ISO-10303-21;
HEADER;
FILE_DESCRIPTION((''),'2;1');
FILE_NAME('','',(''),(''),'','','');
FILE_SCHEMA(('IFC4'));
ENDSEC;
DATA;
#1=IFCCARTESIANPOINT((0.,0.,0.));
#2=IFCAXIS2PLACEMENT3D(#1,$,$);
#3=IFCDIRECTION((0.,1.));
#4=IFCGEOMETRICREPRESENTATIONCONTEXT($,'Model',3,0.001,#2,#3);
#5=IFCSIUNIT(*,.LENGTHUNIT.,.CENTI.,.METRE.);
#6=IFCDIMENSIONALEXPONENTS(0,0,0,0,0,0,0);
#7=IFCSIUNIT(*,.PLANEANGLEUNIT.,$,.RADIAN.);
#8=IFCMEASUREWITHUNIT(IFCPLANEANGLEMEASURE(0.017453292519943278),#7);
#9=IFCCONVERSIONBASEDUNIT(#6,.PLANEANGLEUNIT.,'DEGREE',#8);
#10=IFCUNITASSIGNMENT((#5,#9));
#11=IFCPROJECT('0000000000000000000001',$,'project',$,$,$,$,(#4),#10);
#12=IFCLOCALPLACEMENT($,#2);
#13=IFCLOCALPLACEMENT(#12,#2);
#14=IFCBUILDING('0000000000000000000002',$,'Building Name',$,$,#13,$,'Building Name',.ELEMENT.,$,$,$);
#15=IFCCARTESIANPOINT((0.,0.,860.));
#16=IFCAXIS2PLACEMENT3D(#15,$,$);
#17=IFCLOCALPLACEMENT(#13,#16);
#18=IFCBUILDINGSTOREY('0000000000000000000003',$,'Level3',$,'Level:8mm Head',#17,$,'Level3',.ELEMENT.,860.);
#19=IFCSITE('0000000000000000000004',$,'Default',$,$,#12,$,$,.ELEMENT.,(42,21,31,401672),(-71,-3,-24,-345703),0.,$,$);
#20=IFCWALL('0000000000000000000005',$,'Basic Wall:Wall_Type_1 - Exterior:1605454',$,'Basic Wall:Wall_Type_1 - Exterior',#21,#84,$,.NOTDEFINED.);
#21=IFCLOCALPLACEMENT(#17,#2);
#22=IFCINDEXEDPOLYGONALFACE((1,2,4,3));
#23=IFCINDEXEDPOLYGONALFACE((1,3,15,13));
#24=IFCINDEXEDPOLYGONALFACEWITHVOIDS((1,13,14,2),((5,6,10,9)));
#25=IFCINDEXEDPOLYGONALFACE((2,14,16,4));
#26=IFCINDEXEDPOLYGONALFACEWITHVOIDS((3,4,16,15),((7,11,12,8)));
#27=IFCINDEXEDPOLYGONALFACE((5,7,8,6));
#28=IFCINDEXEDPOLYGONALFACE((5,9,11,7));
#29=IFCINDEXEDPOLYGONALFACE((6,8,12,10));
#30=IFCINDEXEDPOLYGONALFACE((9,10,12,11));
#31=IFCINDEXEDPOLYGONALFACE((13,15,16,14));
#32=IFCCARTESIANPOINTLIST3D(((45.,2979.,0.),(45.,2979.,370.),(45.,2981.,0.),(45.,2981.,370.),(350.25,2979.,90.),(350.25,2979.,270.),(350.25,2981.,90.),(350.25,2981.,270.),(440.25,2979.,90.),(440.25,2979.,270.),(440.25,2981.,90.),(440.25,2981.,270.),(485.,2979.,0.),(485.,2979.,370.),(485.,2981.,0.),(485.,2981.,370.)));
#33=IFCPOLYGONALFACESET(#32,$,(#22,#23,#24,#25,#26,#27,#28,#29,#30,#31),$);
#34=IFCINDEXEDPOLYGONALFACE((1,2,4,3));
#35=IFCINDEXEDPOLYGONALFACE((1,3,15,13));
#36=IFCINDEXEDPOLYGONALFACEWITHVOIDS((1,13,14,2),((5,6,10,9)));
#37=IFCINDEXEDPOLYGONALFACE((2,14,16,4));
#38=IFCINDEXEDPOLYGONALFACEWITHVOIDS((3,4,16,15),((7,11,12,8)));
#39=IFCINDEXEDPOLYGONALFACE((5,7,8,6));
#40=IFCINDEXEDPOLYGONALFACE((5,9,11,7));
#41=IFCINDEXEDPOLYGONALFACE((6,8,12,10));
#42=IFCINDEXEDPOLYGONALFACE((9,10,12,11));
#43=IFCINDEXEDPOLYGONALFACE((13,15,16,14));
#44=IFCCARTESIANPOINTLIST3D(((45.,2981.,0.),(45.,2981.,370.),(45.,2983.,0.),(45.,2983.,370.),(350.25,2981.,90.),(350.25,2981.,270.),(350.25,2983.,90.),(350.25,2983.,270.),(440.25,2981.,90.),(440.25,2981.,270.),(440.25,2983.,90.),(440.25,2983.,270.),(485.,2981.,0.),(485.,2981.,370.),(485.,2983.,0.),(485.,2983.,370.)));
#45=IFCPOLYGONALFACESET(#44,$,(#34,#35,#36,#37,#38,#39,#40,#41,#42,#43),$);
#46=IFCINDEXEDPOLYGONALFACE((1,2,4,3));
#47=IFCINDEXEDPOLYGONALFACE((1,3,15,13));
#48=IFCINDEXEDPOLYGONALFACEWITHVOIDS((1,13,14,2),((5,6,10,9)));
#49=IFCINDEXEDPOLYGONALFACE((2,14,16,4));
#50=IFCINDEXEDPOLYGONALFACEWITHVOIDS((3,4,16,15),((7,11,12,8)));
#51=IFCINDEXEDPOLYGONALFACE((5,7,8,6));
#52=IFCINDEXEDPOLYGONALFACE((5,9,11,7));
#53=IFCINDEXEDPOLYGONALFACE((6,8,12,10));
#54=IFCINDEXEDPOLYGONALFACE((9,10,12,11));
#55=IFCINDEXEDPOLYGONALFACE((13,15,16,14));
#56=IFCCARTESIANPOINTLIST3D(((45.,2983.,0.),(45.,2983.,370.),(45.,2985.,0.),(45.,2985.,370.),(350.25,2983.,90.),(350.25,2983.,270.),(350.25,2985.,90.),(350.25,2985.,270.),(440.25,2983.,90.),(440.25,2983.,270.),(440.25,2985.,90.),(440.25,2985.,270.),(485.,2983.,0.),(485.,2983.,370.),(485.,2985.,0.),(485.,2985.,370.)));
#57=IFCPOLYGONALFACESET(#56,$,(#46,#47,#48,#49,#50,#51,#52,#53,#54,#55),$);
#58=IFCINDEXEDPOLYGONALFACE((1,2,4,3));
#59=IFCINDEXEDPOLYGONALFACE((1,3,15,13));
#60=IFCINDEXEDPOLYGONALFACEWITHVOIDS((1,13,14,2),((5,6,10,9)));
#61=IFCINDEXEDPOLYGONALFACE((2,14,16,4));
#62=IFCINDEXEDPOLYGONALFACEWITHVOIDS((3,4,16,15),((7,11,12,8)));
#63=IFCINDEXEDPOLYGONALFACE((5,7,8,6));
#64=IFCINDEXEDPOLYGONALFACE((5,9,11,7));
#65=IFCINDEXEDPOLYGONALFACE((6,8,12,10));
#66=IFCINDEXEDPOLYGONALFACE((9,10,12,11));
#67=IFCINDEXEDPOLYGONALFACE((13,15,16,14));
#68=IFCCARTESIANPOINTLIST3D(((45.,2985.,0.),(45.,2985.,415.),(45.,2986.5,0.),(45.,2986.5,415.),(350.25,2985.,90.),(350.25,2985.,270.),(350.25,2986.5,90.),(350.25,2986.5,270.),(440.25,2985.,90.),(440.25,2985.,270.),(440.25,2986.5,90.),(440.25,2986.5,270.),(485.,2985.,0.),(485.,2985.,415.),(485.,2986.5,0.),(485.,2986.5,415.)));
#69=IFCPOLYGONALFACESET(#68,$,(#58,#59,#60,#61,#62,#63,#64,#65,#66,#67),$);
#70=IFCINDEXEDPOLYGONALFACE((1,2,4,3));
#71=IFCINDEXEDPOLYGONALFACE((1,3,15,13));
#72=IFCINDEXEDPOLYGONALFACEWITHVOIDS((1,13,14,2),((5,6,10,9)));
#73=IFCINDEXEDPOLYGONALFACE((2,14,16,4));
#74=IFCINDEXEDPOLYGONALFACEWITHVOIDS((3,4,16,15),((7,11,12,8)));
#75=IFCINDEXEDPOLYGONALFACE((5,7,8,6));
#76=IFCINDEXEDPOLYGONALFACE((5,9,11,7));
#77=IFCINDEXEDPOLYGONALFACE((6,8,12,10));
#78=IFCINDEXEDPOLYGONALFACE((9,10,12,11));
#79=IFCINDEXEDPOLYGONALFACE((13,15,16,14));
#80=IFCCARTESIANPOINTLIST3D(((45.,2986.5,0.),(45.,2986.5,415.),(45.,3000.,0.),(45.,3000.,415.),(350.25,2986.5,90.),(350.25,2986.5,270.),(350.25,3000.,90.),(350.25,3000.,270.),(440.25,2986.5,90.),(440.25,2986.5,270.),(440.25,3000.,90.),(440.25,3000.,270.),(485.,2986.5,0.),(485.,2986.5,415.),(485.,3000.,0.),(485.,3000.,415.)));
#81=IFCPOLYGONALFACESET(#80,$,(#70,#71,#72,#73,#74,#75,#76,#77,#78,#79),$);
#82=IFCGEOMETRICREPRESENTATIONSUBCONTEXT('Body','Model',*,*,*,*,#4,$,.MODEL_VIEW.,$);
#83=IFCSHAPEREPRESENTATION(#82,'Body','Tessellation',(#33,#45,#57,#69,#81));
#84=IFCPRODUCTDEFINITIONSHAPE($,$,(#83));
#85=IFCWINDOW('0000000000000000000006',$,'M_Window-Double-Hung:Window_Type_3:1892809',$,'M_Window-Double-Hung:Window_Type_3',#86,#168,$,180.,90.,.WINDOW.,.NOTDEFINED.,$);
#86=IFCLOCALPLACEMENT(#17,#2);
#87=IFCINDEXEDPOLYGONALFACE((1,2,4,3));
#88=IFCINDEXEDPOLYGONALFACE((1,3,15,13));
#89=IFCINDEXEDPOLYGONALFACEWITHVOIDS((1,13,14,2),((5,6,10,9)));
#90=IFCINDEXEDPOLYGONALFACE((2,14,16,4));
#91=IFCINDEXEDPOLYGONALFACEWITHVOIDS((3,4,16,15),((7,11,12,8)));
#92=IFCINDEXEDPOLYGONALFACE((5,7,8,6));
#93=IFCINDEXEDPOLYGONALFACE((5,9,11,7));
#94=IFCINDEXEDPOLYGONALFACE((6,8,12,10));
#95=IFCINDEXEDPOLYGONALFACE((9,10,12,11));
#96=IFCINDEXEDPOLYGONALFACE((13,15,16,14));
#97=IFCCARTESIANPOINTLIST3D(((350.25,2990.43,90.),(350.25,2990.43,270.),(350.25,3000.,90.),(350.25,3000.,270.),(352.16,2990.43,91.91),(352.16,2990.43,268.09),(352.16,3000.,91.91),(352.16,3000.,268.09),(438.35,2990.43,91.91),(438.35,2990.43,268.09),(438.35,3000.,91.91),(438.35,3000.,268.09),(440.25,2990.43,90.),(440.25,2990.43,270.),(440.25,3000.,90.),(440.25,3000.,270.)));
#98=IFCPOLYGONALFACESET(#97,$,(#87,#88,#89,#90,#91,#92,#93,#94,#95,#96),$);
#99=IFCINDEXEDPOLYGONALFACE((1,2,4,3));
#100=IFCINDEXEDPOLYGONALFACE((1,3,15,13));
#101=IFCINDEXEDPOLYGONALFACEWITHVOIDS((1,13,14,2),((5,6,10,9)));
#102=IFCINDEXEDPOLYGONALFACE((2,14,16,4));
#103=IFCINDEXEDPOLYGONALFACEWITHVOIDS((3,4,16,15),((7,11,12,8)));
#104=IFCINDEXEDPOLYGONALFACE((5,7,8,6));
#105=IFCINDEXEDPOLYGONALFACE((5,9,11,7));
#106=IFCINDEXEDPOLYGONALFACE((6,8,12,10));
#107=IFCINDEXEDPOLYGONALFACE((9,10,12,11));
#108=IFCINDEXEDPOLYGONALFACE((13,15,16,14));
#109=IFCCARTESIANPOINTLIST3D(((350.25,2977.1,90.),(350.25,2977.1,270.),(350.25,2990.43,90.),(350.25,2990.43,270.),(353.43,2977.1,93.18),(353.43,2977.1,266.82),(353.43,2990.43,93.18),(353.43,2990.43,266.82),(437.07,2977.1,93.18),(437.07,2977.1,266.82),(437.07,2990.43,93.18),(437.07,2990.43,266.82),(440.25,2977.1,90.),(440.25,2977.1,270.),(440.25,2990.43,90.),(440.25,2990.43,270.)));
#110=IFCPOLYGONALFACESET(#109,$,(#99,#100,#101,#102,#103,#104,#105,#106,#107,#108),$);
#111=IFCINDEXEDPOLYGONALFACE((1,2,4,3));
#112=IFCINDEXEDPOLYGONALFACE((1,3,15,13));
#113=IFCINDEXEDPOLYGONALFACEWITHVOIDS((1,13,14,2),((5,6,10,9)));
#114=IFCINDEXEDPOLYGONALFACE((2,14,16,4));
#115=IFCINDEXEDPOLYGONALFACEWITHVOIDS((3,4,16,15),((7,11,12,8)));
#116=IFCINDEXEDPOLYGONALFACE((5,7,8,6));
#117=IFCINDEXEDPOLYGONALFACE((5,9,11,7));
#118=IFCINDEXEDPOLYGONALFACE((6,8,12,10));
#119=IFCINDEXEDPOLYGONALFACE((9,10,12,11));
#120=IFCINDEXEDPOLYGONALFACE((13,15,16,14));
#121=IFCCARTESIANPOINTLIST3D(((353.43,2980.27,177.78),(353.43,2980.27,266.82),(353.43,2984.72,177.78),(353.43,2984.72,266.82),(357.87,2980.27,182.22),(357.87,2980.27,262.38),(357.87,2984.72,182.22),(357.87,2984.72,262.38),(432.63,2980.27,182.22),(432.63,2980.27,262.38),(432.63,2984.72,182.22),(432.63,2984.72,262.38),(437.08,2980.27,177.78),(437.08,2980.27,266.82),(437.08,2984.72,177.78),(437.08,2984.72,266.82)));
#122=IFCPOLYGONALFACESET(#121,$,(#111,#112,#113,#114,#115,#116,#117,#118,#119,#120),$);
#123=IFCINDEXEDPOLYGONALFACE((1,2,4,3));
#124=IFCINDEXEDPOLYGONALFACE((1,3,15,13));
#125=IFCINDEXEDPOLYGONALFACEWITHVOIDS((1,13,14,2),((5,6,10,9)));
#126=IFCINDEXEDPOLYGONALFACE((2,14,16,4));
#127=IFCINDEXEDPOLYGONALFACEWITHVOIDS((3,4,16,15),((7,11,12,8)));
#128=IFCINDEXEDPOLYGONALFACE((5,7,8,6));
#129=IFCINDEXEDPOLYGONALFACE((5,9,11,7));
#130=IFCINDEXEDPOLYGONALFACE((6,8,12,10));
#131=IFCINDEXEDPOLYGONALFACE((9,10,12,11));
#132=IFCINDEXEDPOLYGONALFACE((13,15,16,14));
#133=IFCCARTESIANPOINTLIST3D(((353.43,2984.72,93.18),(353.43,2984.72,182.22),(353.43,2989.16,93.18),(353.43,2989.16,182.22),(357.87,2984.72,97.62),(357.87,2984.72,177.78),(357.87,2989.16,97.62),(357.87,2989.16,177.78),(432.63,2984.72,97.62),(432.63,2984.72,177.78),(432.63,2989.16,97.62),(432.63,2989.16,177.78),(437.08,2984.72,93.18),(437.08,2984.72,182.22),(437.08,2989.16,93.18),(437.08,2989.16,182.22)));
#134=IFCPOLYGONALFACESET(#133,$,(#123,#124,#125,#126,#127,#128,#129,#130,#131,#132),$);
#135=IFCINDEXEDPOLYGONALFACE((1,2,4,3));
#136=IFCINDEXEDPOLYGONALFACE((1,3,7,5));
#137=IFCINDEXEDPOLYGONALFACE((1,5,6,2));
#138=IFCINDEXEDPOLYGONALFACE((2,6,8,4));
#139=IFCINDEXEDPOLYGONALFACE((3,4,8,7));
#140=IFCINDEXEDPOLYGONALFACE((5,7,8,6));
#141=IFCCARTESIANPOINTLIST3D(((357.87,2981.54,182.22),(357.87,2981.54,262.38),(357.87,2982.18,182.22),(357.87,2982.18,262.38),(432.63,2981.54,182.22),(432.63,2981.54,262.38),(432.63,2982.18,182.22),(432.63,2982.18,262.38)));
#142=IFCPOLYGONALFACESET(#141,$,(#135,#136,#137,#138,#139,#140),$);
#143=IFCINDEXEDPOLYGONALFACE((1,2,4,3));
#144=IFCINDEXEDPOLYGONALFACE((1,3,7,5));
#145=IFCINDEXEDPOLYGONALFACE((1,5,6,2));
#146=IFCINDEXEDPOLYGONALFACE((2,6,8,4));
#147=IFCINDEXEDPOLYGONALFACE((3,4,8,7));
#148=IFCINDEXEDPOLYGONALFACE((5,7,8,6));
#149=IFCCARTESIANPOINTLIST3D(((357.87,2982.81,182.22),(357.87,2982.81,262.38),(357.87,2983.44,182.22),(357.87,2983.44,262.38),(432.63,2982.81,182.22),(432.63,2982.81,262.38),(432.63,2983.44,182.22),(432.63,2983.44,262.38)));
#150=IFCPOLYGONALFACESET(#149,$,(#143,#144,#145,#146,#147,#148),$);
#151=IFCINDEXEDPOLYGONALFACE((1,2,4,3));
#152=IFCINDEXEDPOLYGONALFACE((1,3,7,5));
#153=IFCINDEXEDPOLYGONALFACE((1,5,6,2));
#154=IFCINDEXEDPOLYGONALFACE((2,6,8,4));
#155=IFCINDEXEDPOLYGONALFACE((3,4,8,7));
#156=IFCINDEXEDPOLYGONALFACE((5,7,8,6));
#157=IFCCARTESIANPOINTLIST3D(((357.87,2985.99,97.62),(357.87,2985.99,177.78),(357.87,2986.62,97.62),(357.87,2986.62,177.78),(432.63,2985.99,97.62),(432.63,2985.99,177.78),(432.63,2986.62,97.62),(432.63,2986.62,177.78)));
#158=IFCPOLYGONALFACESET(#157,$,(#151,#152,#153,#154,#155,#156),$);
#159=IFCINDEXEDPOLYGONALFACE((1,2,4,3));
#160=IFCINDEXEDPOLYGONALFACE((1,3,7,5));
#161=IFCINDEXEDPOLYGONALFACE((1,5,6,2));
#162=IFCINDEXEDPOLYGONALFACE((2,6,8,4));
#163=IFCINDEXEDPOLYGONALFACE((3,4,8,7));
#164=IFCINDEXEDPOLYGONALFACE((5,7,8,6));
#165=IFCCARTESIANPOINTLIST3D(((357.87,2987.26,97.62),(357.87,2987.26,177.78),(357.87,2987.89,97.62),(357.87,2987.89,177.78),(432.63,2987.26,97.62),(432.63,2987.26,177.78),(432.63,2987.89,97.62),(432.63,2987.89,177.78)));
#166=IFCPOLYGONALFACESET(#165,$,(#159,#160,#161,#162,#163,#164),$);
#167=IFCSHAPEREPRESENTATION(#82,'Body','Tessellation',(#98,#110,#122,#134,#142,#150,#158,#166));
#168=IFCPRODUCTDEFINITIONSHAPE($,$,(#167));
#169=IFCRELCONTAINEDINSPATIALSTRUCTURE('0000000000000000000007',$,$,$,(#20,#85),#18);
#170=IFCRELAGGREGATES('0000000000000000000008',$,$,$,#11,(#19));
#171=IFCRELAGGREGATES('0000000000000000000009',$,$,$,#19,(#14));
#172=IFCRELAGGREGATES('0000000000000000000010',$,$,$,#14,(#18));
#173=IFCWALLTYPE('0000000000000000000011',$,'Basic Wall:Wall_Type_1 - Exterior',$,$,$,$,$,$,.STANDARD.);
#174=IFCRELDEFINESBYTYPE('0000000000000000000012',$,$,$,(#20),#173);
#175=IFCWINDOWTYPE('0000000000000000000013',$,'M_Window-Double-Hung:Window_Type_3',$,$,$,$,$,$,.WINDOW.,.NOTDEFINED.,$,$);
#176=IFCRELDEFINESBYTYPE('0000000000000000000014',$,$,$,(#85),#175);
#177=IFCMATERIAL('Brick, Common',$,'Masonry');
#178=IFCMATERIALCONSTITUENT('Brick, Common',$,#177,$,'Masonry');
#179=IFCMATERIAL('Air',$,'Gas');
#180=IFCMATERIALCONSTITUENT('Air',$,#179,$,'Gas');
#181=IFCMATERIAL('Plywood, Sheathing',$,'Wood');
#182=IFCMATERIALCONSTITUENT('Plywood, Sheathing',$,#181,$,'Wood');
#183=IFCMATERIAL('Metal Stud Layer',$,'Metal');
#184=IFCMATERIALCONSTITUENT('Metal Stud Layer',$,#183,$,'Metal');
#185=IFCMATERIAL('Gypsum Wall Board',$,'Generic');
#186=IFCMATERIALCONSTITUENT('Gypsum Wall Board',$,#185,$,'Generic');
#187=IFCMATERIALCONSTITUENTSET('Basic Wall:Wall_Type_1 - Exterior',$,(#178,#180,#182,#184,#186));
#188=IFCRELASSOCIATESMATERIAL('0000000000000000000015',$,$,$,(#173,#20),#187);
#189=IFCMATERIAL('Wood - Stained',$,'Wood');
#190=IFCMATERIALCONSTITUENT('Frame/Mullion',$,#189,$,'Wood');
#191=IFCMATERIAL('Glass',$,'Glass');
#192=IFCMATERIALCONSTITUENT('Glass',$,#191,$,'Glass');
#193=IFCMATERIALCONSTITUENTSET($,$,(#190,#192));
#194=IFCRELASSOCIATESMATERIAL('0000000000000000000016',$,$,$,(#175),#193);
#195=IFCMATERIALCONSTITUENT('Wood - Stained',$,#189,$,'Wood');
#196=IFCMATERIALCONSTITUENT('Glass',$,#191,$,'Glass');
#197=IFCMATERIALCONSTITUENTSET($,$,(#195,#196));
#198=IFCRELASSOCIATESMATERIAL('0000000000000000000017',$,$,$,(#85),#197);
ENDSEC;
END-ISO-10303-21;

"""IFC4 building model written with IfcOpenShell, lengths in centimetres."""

from ifc_helpers import new_model, entity, si_unit, converted_unit, direction, frame, origin, place, context, subcontext, project, spatial, indexed_curve, outline, extrude, source, transform, mapped, material, constituent, constituent_set, type_object, type_shapes, element, fill, save


model = new_model("IFC4")

# Units and contexts
model_context = context("Model", 3, precision=0.001, world=origin(), true_north=direction((0.0, 1.0)))
body_context = subcontext(model_context, "Body", "Model", "MODEL_VIEW")
ifc_project = project(units=[si_unit("LENGTHUNIT", "METRE", prefix="CENTI"), converted_unit("PLANEANGLEUNIT", "DEGREE", entity("IfcPlaneAngleMeasure", 0.017453292519943278), si_unit("PLANEANGLEUNIT", "RADIAN"), dimensions=[0, 0, 0, 0, 0, 0, 0])], contexts=[model_context])

# Site, building, storey
site_placement = place(None, origin())
site = spatial("IfcSite", under=ifc_project, at=site_placement, Name="Default", CompositionType="ELEMENT", RefLatitude=(42, 21, 31, 401672), RefLongitude=(-71, -3, -24, -345703), RefElevation=0.0)
building_placement = place(site_placement, origin())
building = spatial("IfcBuilding", under=site, at=building_placement, Name="Building Name", LongName="Building Name", CompositionType="ELEMENT")
storey_placement = place(building_placement, frame((0.0, 0.0, 860.0)))
storey = spatial("IfcBuildingStorey", under=building, at=storey_placement, Name="Level3", ObjectType="Level:8mm Head", LongName="Level3", CompositionType="ELEMENT", Elevation=860.0)

# Wall, opening, window
ifc_material_1 = material(Name="Brick, Common", Category="Masonry")
ifc_constituent_1 = constituent(ifc_material_1, Name="Brick, Common", Category="Masonry")
ifc_material_2 = material(Name="Air", Category="Gas")
ifc_constituent_2 = constituent(ifc_material_2, Name="Air", Category="Gas")
ifc_material_3 = material(Name="Plywood, Sheathing", Category="Wood")
ifc_constituent_3 = constituent(ifc_material_3, Name="Plywood, Sheathing", Category="Wood")
ifc_material_4 = material(Name="Metal Stud Layer", Category="Metal")
ifc_constituent_4 = constituent(ifc_material_4, Name="Metal Stud Layer", Category="Metal")
ifc_material_5 = material(Name="Gypsum Wall Board", Category="Generic")
ifc_constituent_5 = constituent(ifc_material_5, Name="Gypsum Wall Board", Category="Generic")
ifc_constituent_set_1 = constituent_set(constituents=[ifc_constituent_1, ifc_constituent_2, ifc_constituent_3, ifc_constituent_4, ifc_constituent_5], Name="Basic Wall:Wall_Type_1 - Exterior")
wall_type_1 = type_object("IfcWallType", Name="Basic Wall:Wall_Type_1 - Exterior", PredefinedType="STANDARD", material=ifc_constituent_set_1)
wall_1_placement = place(storey_placement, frame((45.0, 2989.5, 0.0)))
wall_1 = element("IfcWall", 1, at=wall_1_placement, inside=storey, type_object=wall_type_1, material=ifc_constituent_set_1, Name="Basic Wall:Wall_Type_1 - Exterior:1605454", ObjectType="Basic Wall:Wall_Type_1 - Exterior", PredefinedType="NOTDEFINED", context=body_context, shape_type="SweptSolid", body=[
    extrude(outline(indexed_curve([(-185.0, -240.63), (185.0, -240.63), (185.0, 16.37), (185.0, 24.87), (185.0, 199.38), (-185.0, 199.38), (-185.0, 24.87), (-185.0, 16.37), (-185.0, -240.63)], self_intersect=False), holes=[indexed_curve([(85.0, 154.62), (85.0, 64.62), (-95.0, 64.62), (-95.0, 154.62), (85.0, 154.62)], self_intersect=False)]), frame((240.63, -10.5, 185.0), z_axis=(0.0, 1.0, 0.0), x_axis=(0.0, 0.0, 1.0)), (0.0, 0.0, 1.0), 2.0),
    extrude(outline(indexed_curve([(-185.0, -220.0), (185.0, -220.0), (185.0, 220.0), (-185.0, 220.0), (-185.0, -220.0)], self_intersect=False), holes=[indexed_curve([(85.0, 175.25), (85.0, 85.25), (-95.0, 85.25), (-95.0, 175.25), (85.0, 175.25)], self_intersect=False)]), frame((220.0, -8.5, 185.0), z_axis=(0.0, 1.0, 0.0), x_axis=(0.0, 0.0, 1.0)), (0.0, 0.0, 1.0), 2.0),
    extrude(outline(indexed_curve([(-185.0, -220.0), (185.0, -220.0), (185.0, 220.0), (-185.0, 220.0), (-185.0, -220.0)], self_intersect=False), holes=[indexed_curve([(85.0, 175.25), (85.0, 85.25), (-95.0, 85.25), (-95.0, 175.25), (85.0, 175.25)], self_intersect=False)]), frame((220.0, -6.5, 185.0), z_axis=(0.0, 1.0, 0.0), x_axis=(0.0, 0.0, 1.0)), (0.0, 0.0, 1.0), 2.0),
    extrude(outline(indexed_curve([(-261.67, -220.0), (108.33, -220.0), (153.33, -220.0), (153.33, 220.0), (108.33, 220.0), (-261.67, 220.0), (-261.67, -220.0)], self_intersect=False), holes=[indexed_curve([(8.33, 175.25), (8.33, 85.25), (-171.67, 85.25), (-171.67, 175.25), (8.33, 175.25)], self_intersect=False)]), frame((220.0, -4.5, 261.67), z_axis=(0.0, 1.0, 0.0), x_axis=(0.0, 0.0, 1.0)), (0.0, 0.0, 1.0), 1.5),
    extrude(outline(indexed_curve([(-207.5, -220.0), (207.5, -220.0), (207.5, 220.0), (-207.5, 220.0), (-207.5, -220.0)], self_intersect=False), holes=[indexed_curve([(62.5, 175.25), (62.5, 85.25), (-117.5, 85.25), (-117.5, 175.25), (62.5, 175.25)], self_intersect=False)]), frame((220.0, -3.0, 207.5), z_axis=(0.0, 1.0, 0.0), x_axis=(0.0, 0.0, 1.0)), (0.0, 0.0, 1.0), 13.5),
])
opening_1_placement = place(wall_1_placement, frame((395.25, 10.5, 90.0)))
opening_1 = element("IfcOpeningElement", 2, at=opening_1_placement, cuts=wall_1, PredefinedType="OPENING", context=body_context, shape_type="SweptSolid", body=[
    extrude(outline(indexed_curve([(180.0, 0.0), (180.0, 90.0), (0.0, 90.0), (0.0, 0.0), (180.0, 0.0)], self_intersect=False)), frame((0.0, 0.0, 0.0), z_axis=(0.0, -1.0, 0.0), x_axis=(0.0, 0.0, 1.0)), (0.0, 0.0, 1.0), 21.0),
])
ifc_material_6 = material(Name="Wood - Stained", Category="Wood")
ifc_constituent_6 = constituent(ifc_material_6, Name="Wood - Stained", Category="Wood")
ifc_material_7 = material(Name="Glass", Category="Glass")
ifc_constituent_7 = constituent(ifc_material_7, Name="Glass", Category="Glass")
ifc_constituent_set_2 = constituent_set(constituents=[ifc_constituent_6, ifc_constituent_7])
ifc_constituent_8 = constituent(ifc_material_6, Name="Frame/Mullion", Category="Wood")
ifc_constituent_9 = constituent(ifc_material_7, Name="Glass", Category="Glass")
ifc_constituent_set_3 = constituent_set(constituents=[ifc_constituent_8, ifc_constituent_9])
window_type = type_object("IfcWindowType", Name="M_Window-Double-Hung:Window_Type_3", PartitioningType="NOTDEFINED", PredefinedType="WINDOW", material=ifc_constituent_set_3)
shared_shape_1 = source(origin(), body_context, "Body", "SweptSolid", [
    extrude(outline(indexed_curve([(-90.0, -45.0), (90.0, -45.0), (90.0, 45.0), (-90.0, 45.0), (-90.0, -45.0)], self_intersect=False), holes=[indexed_curve([(-88.09, -43.09), (-88.09, 43.09), (88.09, 43.09), (88.09, -43.09), (-88.09, -43.09)], self_intersect=False)]), frame((45.0, 0.0, 90.0), z_axis=(0.0, 1.0, 0.0), x_axis=(0.0, 0.0, -1.0)), (0.0, 0.0, 1.0), 9.57),
    extrude(outline(indexed_curve([(-45.0, -90.0), (45.0, -90.0), (45.0, 90.0), (-45.0, 90.0), (-45.0, -90.0)], self_intersect=False), holes=[indexed_curve([(41.82, -86.82), (-41.82, -86.82), (-41.82, 86.82), (41.82, 86.82), (41.82, -86.82)], self_intersect=False)]), frame((45.0, 9.57, 90.0), z_axis=(0.0, 1.0, 0.0), x_axis=(1.0, 0.0, 0.0)), (0.0, 0.0, 1.0), 13.33),
    extrude(outline(indexed_curve([(-41.82, -44.52), (41.82, -44.52), (41.82, 44.52), (-41.82, 44.52), (-41.82, -44.52)], self_intersect=False), holes=[indexed_curve([(37.38, -40.08), (-37.38, -40.08), (-37.38, 40.08), (37.38, 40.08), (37.38, -40.08)], self_intersect=False)]), frame((45.0, 15.28, 132.3), z_axis=(0.0, 1.0, 0.0), x_axis=(1.0, 0.0, 0.0)), (0.0, 0.0, 1.0), 4.45),
    extrude(outline(indexed_curve([(-41.82, -44.52), (41.82, -44.52), (41.82, 44.52), (-41.82, 44.52), (-41.82, -44.52)], self_intersect=False), holes=[indexed_curve([(37.38, -40.08), (-37.38, -40.08), (-37.38, 40.08), (37.38, 40.08), (37.38, -40.08)], self_intersect=False)]), frame((45.0, 10.84, 47.7), z_axis=(0.0, 1.0, 0.0), x_axis=(1.0, 0.0, 0.0)), (0.0, 0.0, 1.0), 4.45),
    extrude(outline(indexed_curve([(-37.38, -0.32), (37.38, -0.32), (37.38, 0.32), (-37.38, 0.32), (-37.38, -0.32)], self_intersect=False)), frame((45.0, 18.14, 92.22), z_axis=(0.0, 0.0, 1.0), x_axis=(-1.0, 0.0, 0.0)), (0.0, 0.0, 1.0), 80.16),
    extrude(outline(indexed_curve([(-0.32, -37.38), (0.32, -37.38), (0.32, 37.38), (-0.32, 37.38), (-0.32, -37.38)], self_intersect=False)), frame((45.0, 16.87, 92.22), z_axis=(0.0, 0.0, 1.0), x_axis=(0.0, -1.0, 0.0)), (0.0, 0.0, 1.0), 80.16),
    extrude(outline(indexed_curve([(-37.38, -0.32), (37.38, -0.32), (37.38, 0.32), (-37.38, 0.32), (-37.38, -0.32)], self_intersect=False)), frame((45.0, 13.7, 7.62), z_axis=(0.0, 0.0, 1.0), x_axis=(-1.0, 0.0, 0.0)), (0.0, 0.0, 1.0), 80.16),
    extrude(outline(indexed_curve([(-0.32, -37.38), (0.32, -37.38), (0.32, 37.38), (-0.32, 37.38), (-0.32, -37.38)], self_intersect=False)), frame((45.0, 12.43, 7.62), z_axis=(0.0, 0.0, 1.0), x_axis=(0.0, -1.0, 0.0)), (0.0, 0.0, 1.0), 80.16),
])
type_shapes(window_type, [shared_shape_1])
window_1_placement = place(opening_1_placement, frame((0.0, 0.0, 0.0), z_axis=(0.0, 0.0, 1.0), x_axis=(-1.0, 0.0, 0.0)))
window_1 = element("IfcWindow", 3, at=window_1_placement, inside=storey, type_object=window_type, material=ifc_constituent_set_2, Name="M_Window-Double-Hung:Window_Type_3:1892809", ObjectType="M_Window-Double-Hung:Window_Type_3", OverallHeight=180.0, OverallWidth=90.0, PartitioningType="NOTDEFINED", PredefinedType="WINDOW", context=body_context, shape_type="MappedRepresentation", body=[
    mapped(shared_shape_1, transform((0.0, 0.0, 0.0), scale=1.0)),
])
fill(opening_1, window_1)

save(model, "model.ifc")
